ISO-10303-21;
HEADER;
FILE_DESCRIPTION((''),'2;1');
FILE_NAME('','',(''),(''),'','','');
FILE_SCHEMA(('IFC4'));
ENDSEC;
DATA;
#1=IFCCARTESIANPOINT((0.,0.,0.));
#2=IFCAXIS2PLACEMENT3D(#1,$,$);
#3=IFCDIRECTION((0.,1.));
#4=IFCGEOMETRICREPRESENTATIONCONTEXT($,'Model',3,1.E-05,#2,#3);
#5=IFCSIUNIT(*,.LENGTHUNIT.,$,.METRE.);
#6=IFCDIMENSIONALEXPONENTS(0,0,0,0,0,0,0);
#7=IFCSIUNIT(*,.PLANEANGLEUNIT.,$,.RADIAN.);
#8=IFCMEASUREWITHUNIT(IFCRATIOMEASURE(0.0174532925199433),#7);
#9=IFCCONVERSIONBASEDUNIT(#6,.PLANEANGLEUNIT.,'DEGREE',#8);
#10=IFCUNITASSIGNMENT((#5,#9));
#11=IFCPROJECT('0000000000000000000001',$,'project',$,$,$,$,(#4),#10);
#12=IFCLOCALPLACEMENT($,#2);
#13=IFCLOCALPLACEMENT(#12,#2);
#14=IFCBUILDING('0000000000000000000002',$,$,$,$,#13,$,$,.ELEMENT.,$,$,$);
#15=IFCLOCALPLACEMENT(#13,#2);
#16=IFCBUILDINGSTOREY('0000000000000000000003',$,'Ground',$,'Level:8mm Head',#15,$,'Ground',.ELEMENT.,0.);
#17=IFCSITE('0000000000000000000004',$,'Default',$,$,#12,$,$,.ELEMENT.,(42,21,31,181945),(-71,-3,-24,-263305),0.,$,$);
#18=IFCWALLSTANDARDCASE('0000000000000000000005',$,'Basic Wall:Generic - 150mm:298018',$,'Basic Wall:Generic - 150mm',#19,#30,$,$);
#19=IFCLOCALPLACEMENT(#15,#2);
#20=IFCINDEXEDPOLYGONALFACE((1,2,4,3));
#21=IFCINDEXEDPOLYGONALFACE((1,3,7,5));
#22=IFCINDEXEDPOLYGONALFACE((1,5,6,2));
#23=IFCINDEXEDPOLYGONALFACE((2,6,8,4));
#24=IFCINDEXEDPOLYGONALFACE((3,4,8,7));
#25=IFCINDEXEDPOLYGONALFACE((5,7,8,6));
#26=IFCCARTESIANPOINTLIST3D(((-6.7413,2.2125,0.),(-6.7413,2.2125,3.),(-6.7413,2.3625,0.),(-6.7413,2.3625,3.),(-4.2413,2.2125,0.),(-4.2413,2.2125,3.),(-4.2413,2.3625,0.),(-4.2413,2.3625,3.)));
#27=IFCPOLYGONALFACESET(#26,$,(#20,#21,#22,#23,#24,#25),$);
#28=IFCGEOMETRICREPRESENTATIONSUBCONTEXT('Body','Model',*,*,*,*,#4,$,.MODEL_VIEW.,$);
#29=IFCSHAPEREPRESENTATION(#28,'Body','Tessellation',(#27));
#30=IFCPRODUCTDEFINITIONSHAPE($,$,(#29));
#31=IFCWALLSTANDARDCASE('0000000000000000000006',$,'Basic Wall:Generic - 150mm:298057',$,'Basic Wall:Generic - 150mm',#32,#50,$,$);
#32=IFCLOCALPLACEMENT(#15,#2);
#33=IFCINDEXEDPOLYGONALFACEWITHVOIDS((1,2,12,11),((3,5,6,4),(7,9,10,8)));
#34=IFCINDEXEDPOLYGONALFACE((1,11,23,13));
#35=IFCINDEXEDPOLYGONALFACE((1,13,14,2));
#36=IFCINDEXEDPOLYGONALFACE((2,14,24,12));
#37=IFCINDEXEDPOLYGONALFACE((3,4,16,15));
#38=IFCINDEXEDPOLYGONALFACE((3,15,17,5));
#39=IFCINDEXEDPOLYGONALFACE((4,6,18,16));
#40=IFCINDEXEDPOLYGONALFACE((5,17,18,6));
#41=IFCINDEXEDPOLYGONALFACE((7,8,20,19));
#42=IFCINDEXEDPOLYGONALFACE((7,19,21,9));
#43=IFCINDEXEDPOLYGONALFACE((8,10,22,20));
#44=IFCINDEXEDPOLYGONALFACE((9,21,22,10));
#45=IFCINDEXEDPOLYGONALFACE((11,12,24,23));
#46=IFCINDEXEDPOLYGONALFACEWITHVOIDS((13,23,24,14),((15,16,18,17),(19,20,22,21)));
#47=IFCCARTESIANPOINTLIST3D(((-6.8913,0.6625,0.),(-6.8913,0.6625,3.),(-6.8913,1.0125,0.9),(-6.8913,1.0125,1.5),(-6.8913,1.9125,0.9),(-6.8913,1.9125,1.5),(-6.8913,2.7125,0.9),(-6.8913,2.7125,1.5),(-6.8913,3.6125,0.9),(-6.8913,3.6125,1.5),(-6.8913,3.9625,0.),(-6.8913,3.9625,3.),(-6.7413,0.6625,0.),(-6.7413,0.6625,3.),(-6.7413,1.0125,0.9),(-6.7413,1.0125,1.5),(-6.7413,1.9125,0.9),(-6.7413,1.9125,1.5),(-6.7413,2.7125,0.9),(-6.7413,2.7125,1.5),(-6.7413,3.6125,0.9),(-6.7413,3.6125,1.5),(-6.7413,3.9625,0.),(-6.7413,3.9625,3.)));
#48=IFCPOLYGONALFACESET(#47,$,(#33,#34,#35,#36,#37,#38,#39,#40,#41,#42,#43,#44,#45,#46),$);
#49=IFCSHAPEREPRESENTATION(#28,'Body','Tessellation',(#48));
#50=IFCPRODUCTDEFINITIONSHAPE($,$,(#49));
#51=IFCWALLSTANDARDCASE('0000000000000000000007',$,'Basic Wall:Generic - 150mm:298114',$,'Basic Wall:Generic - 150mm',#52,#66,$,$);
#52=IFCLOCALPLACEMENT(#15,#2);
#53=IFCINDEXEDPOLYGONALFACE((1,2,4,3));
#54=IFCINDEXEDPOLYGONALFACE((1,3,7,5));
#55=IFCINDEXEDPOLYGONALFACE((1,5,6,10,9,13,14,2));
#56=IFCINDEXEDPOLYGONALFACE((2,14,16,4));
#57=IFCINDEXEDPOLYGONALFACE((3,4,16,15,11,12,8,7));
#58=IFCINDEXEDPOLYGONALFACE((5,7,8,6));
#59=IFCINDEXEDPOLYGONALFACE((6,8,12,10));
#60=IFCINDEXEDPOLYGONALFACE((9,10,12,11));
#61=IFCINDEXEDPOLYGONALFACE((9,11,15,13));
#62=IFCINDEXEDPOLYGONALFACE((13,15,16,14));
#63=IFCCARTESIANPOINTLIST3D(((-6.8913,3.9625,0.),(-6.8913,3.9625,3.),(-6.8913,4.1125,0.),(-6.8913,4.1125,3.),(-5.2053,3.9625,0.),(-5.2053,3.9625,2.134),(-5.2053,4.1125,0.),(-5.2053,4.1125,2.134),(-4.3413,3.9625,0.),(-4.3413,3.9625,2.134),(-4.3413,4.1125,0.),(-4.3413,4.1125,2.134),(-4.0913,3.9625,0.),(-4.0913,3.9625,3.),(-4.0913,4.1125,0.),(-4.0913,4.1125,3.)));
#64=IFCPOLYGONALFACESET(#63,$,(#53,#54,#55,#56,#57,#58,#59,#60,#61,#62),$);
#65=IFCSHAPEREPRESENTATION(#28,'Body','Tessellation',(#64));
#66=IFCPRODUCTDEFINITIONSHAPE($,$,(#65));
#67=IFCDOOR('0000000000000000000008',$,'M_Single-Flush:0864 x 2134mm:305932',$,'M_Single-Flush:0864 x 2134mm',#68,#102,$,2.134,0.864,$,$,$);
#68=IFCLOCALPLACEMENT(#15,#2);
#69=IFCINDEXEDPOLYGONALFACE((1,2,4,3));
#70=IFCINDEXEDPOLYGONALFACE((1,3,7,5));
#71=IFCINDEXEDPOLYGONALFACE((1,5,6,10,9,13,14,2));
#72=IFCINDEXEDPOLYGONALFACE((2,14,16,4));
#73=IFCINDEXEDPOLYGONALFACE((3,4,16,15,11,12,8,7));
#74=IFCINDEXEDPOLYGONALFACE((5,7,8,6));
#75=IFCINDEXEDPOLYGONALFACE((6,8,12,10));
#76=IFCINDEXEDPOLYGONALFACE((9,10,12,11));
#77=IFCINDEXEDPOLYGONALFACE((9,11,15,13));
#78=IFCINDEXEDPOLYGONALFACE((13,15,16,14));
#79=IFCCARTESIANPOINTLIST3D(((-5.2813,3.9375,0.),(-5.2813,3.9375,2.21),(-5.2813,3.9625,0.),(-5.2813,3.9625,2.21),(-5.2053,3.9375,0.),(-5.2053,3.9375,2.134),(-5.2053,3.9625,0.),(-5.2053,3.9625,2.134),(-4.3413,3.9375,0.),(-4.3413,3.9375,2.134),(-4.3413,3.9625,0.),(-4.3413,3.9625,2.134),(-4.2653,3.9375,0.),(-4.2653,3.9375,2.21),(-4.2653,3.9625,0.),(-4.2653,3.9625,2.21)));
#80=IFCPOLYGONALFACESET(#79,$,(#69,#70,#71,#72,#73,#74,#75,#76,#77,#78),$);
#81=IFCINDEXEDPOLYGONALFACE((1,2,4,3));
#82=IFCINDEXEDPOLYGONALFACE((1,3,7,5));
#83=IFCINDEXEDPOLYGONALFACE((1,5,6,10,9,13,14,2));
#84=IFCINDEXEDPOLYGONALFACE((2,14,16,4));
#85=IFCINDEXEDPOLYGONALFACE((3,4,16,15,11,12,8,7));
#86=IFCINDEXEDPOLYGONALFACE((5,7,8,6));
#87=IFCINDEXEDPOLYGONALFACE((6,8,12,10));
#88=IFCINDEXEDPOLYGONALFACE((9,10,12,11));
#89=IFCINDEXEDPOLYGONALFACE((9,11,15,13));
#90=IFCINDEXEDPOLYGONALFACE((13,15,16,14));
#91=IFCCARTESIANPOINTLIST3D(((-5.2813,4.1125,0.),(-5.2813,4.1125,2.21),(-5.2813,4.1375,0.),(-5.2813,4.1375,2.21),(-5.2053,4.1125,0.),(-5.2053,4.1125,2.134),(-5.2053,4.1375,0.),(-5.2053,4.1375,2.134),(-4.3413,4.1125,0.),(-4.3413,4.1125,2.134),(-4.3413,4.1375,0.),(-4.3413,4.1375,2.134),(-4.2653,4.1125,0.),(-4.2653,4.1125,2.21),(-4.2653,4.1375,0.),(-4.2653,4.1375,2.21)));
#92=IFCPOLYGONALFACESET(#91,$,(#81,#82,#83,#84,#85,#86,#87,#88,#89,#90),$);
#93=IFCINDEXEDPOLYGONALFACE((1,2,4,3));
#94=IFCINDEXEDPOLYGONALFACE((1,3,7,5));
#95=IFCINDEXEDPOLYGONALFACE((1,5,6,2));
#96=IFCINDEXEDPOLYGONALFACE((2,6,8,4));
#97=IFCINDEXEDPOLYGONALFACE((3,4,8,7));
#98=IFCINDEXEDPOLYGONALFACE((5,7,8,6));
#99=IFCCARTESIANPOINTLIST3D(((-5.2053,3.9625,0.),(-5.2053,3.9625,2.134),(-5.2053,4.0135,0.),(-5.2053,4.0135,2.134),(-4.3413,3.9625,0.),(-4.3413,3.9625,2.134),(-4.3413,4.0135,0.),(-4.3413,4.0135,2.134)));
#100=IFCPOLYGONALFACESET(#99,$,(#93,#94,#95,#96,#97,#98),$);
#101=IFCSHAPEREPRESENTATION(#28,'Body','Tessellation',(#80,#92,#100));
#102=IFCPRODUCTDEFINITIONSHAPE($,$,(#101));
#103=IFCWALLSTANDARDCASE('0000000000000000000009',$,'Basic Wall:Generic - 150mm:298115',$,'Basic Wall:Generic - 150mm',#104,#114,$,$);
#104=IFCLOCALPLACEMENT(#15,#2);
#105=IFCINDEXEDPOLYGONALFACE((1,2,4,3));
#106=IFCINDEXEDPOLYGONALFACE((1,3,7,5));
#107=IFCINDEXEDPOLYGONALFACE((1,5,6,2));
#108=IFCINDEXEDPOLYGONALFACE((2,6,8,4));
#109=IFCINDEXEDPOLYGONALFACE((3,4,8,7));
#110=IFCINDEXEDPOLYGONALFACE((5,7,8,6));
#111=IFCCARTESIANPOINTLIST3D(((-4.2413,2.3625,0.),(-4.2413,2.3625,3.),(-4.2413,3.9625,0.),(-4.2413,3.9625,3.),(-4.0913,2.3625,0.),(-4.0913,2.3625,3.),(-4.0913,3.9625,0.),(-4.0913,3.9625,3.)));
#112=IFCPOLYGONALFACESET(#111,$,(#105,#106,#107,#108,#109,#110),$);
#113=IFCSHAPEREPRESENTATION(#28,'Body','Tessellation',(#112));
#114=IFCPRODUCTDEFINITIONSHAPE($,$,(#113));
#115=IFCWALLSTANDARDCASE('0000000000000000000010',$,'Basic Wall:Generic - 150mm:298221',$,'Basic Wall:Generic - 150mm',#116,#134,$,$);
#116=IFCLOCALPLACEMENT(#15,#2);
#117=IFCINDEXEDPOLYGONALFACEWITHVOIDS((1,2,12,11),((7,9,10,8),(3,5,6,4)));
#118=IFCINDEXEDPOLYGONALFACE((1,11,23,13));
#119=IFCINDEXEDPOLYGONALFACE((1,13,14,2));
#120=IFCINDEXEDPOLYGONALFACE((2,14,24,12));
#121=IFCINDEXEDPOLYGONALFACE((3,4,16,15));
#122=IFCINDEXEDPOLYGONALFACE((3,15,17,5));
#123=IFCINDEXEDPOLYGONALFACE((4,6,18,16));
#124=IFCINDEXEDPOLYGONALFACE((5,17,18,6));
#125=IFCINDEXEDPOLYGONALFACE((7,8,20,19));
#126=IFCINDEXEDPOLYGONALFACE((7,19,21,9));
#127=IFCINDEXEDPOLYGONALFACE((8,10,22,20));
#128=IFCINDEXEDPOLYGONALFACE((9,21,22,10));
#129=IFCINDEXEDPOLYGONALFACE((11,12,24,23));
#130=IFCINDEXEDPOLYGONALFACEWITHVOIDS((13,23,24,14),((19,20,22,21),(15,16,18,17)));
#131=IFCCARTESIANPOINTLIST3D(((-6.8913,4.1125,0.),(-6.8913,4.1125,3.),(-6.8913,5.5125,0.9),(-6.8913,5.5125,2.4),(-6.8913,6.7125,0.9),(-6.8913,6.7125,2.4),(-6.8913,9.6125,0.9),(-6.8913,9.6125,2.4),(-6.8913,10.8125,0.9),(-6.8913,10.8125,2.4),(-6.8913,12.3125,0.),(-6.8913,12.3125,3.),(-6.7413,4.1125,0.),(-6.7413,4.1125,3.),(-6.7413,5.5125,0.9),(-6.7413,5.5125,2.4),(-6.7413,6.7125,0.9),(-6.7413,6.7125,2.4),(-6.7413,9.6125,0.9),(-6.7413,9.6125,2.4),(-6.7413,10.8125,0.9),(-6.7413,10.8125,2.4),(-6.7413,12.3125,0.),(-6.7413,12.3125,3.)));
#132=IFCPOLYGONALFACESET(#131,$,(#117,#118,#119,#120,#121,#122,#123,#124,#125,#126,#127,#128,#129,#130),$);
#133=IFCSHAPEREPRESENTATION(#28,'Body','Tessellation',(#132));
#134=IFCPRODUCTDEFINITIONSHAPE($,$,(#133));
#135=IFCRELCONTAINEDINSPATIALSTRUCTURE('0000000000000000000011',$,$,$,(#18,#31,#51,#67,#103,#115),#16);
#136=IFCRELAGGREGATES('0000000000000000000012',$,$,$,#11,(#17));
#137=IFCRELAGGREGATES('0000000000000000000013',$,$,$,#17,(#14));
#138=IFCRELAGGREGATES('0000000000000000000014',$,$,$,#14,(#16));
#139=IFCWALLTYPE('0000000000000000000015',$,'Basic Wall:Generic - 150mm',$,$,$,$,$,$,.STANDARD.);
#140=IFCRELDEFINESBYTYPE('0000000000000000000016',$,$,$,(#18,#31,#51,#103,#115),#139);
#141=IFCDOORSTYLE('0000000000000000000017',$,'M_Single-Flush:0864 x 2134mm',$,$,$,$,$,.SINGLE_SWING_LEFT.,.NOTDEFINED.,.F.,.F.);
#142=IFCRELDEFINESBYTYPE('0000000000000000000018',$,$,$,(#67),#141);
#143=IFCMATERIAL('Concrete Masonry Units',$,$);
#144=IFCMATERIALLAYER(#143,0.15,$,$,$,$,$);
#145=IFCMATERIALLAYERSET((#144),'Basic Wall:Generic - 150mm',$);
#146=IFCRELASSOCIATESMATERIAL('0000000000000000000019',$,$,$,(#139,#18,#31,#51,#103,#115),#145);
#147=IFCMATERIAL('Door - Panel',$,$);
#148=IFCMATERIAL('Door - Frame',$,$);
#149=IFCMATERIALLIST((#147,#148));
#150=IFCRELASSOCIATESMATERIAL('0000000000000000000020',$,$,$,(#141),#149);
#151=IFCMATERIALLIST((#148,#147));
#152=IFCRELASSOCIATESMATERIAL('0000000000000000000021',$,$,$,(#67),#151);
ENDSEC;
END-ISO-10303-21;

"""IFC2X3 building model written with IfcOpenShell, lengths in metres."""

from ifc_helpers import new_model, entity, si_unit, converted_unit, direction, frame, frame_2d, origin, place, context, subcontext, project, spatial, polyline, rectangle, outline, extrude, source, transform, mapped, material, material_list, layer, layer_set, layer_usage, type_object, type_shapes, element, fill, save


model = new_model("IFC2X3")

# Units and contexts
model_context = context("Model", 3, precision=1e-05, world=origin(), true_north=direction((0.0, 1.0)))
body_context = subcontext(model_context, "Body", "Model", "MODEL_VIEW")
ifc_project = project(units=[si_unit("LENGTHUNIT", "METRE"), converted_unit("PLANEANGLEUNIT", "DEGREE", entity("IfcRatioMeasure", 0.0174532925199433), si_unit("PLANEANGLEUNIT", "RADIAN"), dimensions=[0, 0, 0, 0, 0, 0, 0])], contexts=[model_context])

# Site, building, storey
site_placement = place(None, origin())
site = spatial("IfcSite", under=ifc_project, at=site_placement, Name="Default", CompositionType="ELEMENT", RefLatitude=(42, 21, 31, 181945), RefLongitude=(-71, -3, -24, -263305), RefElevation=0.0)
building_placement = place(site_placement, origin())
building = spatial("IfcBuilding", under=site, at=building_placement, CompositionType="ELEMENT")
storey_placement = place(building_placement, origin())
storey = spatial("IfcBuildingStorey", under=building, at=storey_placement, Name="Ground", ObjectType="Level:8mm Head", LongName="Ground", CompositionType="ELEMENT", Elevation=0.0)

# Wall
ifc_material_1 = material(Name="Concrete Masonry Units")
ifc_layer = layer(ifc_material_1, 0.15)
ifc_layer_set = layer_set([ifc_layer], Name="Basic Wall:Generic - 150mm")
ifc_layer_usage_1 = layer_usage(ifc_layer_set, "AXIS2", "NEGATIVE", 0.075)
wall_type = type_object("IfcWallType", Name="Basic Wall:Generic - 150mm", PredefinedType="STANDARD", material=ifc_layer_set)
wall_1_placement = place(storey_placement, frame((-4.2413, 2.2875, 0.0), z_axis=(0.0, 0.0, 1.0), x_axis=(-1.0, 0.0, 0.0)))
element("IfcWallStandardCase", 1, at=wall_1_placement, inside=storey, type_object=wall_type, material=ifc_layer_usage_1, Name="Basic Wall:Generic - 150mm:298018", ObjectType="Basic Wall:Generic - 150mm", context=body_context, shape_type="SweptSolid", body=[
    extrude(rectangle(XDim=2.5, YDim=0.15, at=frame_2d((1.25, 0.0), x_axis=(-1.0, 0.0))), origin(), (0.0, 0.0, 1.0), 3.0),
])

# Wall, openings
ifc_layer_usage_2 = layer_usage(ifc_layer_set, "AXIS2", "NEGATIVE", 0.075)
wall_2_placement = place(storey_placement, frame((-6.8163, 3.9625, 0.0), z_axis=(0.0, 0.0, 1.0), x_axis=(0.0, -1.0, 0.0)))
wall_2 = element("IfcWallStandardCase", 2, at=wall_2_placement, inside=storey, type_object=wall_type, material=ifc_layer_usage_2, Name="Basic Wall:Generic - 150mm:298057", ObjectType="Basic Wall:Generic - 150mm", context=body_context, shape_type="SweptSolid", body=[
    extrude(rectangle(XDim=3.3, YDim=0.15, at=frame_2d((1.65, 0.0), x_axis=(-1.0, 0.0))), origin(), (0.0, 0.0, 1.0), 3.0),
])
opening_1_placement = place(wall_2_placement, frame((2.05, -0.075, 0.9)))
element("IfcOpeningElement", 3, at=opening_1_placement, cuts=wall_2, ObjectType="Opening", context=body_context, shape_type="SweptSolid", body=[
    extrude(rectangle(XDim=0.6, YDim=0.9, at=frame_2d((0.3, 0.45), x_axis=(-1.0, 0.0))), frame((0.0, 0.0, 0.0), z_axis=(0.0, 1.0, 0.0), x_axis=(0.0, 0.0, 1.0)), (0.0, 0.0, 1.0), 0.15),
])
opening_2_placement = place(wall_2_placement, frame((0.35, -0.075, 0.9)))
element("IfcOpeningElement", 4, at=opening_2_placement, cuts=wall_2, ObjectType="Opening", context=body_context, shape_type="SweptSolid", body=[
    extrude(rectangle(XDim=0.6, YDim=0.9, at=frame_2d((0.3, 0.45), x_axis=(-1.0, 0.0))), frame((0.0, 0.0, 0.0), z_axis=(0.0, 1.0, 0.0), x_axis=(0.0, 0.0, 1.0)), (0.0, 0.0, 1.0), 0.15),
])

# Wall, opening, door
ifc_layer_usage_3 = layer_usage(ifc_layer_set, "AXIS2", "NEGATIVE", 0.075)
wall_3_placement = place(storey_placement, frame((-6.8913, 4.0375, 0.0)))
wall_3 = element("IfcWallStandardCase", 5, at=wall_3_placement, inside=storey, type_object=wall_type, material=ifc_layer_usage_3, Name="Basic Wall:Generic - 150mm:298114", ObjectType="Basic Wall:Generic - 150mm", context=body_context, shape_type="SweptSolid", body=[
    extrude(rectangle(XDim=2.8, YDim=0.15, at=frame_2d((1.4, 0.0), x_axis=(-1.0, 0.0))), origin(), (0.0, 0.0, 1.0), 3.0),
])
opening_3_placement = place(wall_3_placement, frame((2.55, 0.075, 0.0)))
opening_3 = element("IfcOpeningElement", 6, at=opening_3_placement, cuts=wall_3, ObjectType="Opening", context=body_context, shape_type="SweptSolid", body=[
    extrude(rectangle(XDim=0.864, YDim=2.134, at=frame_2d((1.067, 0.432), x_axis=(0.0, -1.0))), frame((0.0, 0.0, 0.0), z_axis=(0.0, -1.0, 0.0), x_axis=(0.0, 0.0, 1.0)), (0.0, 0.0, 1.0), 0.15),
])
ifc_material_2 = material(Name="Door - Frame")
ifc_material_3 = material(Name="Door - Panel")
ifc_material_list_1 = material_list([ifc_material_2, ifc_material_3])
ifc_material_list_2 = material_list([ifc_material_3, ifc_material_2])
door_style_1 = type_object("IfcDoorStyle", Name="M_Single-Flush:0864 x 2134mm", ConstructionType="NOTDEFINED", OperationType="SINGLE_SWING_LEFT", ParameterTakesPrecedence=False, Sizeable=False, material=ifc_material_list_2)
shared_shape_1 = source(origin(), body_context, "Body", "SweptSolid", [
    extrude(outline(polyline([(-0.508, -1.124), (0.508, -1.124), (0.508, 1.086), (0.432, 1.086), (0.432, -1.048), (-0.432, -1.048), (-0.432, 1.086), (-0.508, 1.086), (-0.508, -1.124)])), frame((0.432, 0.175, 1.086), z_axis=(0.0, -1.0, 0.0), x_axis=(-1.0, 0.0, 0.0)), (0.0, 0.0, 1.0), 0.025),
    extrude(outline(polyline([(-1.124, -0.508), (1.086, -0.508), (1.086, -0.432), (-1.048, -0.432), (-1.048, 0.432), (1.086, 0.432), (1.086, 0.508), (-1.124, 0.508), (-1.124, -0.508)])), frame((0.432, 0.0, 1.086), z_axis=(0.0, -1.0, 0.0), x_axis=(0.0, 0.0, -1.0)), (0.0, 0.0, 1.0), 0.025),
    extrude(rectangle(XDim=0.864, YDim=0.051, at=frame_2d((0.0, 0.0), x_axis=(1.0, 0.0))), frame((0.432, 0.1245, 0.0)), (0.0, 0.0, 1.0), 2.134),
])
type_shapes(door_style_1, [shared_shape_1])
door_1_placement = place(opening_3_placement, frame((0.0, 0.0, 0.0), z_axis=(0.0, 0.0, 1.0), x_axis=(-1.0, 0.0, 0.0)))
door_1 = element("IfcDoor", 7, at=door_1_placement, inside=storey, type_object=door_style_1, material=ifc_material_list_1, Name="M_Single-Flush:0864 x 2134mm:305932", ObjectType="M_Single-Flush:0864 x 2134mm", OverallHeight=2.134, OverallWidth=0.864, context=body_context, shape_type="MappedRepresentation", body=[
    mapped(shared_shape_1, transform((0.0, 0.0, 0.0), scale=1.0)),
])
fill(opening_3, door_1)

# Wall
ifc_layer_usage_4 = layer_usage(ifc_layer_set, "AXIS2", "POSITIVE", -0.075)
wall_4_placement = place(storey_placement, frame((-4.1663, 3.9625, 0.0), z_axis=(0.0, 0.0, 1.0), x_axis=(0.0, -1.0, 0.0)))
element("IfcWallStandardCase", 8, at=wall_4_placement, inside=storey, type_object=wall_type, material=ifc_layer_usage_4, Name="Basic Wall:Generic - 150mm:298115", ObjectType="Basic Wall:Generic - 150mm", context=body_context, shape_type="SweptSolid", body=[
    extrude(rectangle(XDim=1.6, YDim=0.15, at=frame_2d((0.8, 0.0), x_axis=(-1.0, 0.0))), origin(), (0.0, 0.0, 1.0), 3.0),
])

# Wall, openings
ifc_layer_usage_5 = layer_usage(ifc_layer_set, "AXIS2", "NEGATIVE", 0.075)
wall_5_placement = place(storey_placement, frame((-6.8163, 4.1125, 0.0), z_axis=(0.0, 0.0, 1.0), x_axis=(0.0, 1.0, 0.0)))
wall_5 = element("IfcWallStandardCase", 9, at=wall_5_placement, inside=storey, type_object=wall_type, material=ifc_layer_usage_5, Name="Basic Wall:Generic - 150mm:298221", ObjectType="Basic Wall:Generic - 150mm", context=body_context, shape_type="SweptSolid", body=[
    extrude(rectangle(XDim=8.2, YDim=0.15, at=frame_2d((4.1, 0.0), x_axis=(-1.0, 0.0))), origin(), (0.0, 0.0, 1.0), 3.0),
])
opening_4_placement = place(wall_5_placement, frame((2.6, 0.075, 0.9)))
element("IfcOpeningElement", 10, at=opening_4_placement, cuts=wall_5, ObjectType="Opening", context=body_context, shape_type="SweptSolid", body=[
    extrude(rectangle(XDim=1.5, YDim=1.2, at=frame_2d((0.75, 0.6), x_axis=(-1.0, 0.0))), frame((0.0, 0.0, 0.0), z_axis=(0.0, -1.0, 0.0), x_axis=(0.0, 0.0, 1.0)), (0.0, 0.0, 1.0), 0.15),
])
opening_5_placement = place(wall_5_placement, frame((6.7, 0.075, 0.9)))
element("IfcOpeningElement", 11, at=opening_5_placement, cuts=wall_5, ObjectType="Opening", context=body_context, shape_type="SweptSolid", body=[
    extrude(rectangle(XDim=1.5, YDim=1.2, at=frame_2d((0.75, 0.6), x_axis=(-1.0, 0.0))), frame((0.0, 0.0, 0.0), z_axis=(0.0, -1.0, 0.0), x_axis=(0.0, 0.0, 1.0)), (0.0, 0.0, 1.0), 0.15),
])

save(model, "model.ifc")
